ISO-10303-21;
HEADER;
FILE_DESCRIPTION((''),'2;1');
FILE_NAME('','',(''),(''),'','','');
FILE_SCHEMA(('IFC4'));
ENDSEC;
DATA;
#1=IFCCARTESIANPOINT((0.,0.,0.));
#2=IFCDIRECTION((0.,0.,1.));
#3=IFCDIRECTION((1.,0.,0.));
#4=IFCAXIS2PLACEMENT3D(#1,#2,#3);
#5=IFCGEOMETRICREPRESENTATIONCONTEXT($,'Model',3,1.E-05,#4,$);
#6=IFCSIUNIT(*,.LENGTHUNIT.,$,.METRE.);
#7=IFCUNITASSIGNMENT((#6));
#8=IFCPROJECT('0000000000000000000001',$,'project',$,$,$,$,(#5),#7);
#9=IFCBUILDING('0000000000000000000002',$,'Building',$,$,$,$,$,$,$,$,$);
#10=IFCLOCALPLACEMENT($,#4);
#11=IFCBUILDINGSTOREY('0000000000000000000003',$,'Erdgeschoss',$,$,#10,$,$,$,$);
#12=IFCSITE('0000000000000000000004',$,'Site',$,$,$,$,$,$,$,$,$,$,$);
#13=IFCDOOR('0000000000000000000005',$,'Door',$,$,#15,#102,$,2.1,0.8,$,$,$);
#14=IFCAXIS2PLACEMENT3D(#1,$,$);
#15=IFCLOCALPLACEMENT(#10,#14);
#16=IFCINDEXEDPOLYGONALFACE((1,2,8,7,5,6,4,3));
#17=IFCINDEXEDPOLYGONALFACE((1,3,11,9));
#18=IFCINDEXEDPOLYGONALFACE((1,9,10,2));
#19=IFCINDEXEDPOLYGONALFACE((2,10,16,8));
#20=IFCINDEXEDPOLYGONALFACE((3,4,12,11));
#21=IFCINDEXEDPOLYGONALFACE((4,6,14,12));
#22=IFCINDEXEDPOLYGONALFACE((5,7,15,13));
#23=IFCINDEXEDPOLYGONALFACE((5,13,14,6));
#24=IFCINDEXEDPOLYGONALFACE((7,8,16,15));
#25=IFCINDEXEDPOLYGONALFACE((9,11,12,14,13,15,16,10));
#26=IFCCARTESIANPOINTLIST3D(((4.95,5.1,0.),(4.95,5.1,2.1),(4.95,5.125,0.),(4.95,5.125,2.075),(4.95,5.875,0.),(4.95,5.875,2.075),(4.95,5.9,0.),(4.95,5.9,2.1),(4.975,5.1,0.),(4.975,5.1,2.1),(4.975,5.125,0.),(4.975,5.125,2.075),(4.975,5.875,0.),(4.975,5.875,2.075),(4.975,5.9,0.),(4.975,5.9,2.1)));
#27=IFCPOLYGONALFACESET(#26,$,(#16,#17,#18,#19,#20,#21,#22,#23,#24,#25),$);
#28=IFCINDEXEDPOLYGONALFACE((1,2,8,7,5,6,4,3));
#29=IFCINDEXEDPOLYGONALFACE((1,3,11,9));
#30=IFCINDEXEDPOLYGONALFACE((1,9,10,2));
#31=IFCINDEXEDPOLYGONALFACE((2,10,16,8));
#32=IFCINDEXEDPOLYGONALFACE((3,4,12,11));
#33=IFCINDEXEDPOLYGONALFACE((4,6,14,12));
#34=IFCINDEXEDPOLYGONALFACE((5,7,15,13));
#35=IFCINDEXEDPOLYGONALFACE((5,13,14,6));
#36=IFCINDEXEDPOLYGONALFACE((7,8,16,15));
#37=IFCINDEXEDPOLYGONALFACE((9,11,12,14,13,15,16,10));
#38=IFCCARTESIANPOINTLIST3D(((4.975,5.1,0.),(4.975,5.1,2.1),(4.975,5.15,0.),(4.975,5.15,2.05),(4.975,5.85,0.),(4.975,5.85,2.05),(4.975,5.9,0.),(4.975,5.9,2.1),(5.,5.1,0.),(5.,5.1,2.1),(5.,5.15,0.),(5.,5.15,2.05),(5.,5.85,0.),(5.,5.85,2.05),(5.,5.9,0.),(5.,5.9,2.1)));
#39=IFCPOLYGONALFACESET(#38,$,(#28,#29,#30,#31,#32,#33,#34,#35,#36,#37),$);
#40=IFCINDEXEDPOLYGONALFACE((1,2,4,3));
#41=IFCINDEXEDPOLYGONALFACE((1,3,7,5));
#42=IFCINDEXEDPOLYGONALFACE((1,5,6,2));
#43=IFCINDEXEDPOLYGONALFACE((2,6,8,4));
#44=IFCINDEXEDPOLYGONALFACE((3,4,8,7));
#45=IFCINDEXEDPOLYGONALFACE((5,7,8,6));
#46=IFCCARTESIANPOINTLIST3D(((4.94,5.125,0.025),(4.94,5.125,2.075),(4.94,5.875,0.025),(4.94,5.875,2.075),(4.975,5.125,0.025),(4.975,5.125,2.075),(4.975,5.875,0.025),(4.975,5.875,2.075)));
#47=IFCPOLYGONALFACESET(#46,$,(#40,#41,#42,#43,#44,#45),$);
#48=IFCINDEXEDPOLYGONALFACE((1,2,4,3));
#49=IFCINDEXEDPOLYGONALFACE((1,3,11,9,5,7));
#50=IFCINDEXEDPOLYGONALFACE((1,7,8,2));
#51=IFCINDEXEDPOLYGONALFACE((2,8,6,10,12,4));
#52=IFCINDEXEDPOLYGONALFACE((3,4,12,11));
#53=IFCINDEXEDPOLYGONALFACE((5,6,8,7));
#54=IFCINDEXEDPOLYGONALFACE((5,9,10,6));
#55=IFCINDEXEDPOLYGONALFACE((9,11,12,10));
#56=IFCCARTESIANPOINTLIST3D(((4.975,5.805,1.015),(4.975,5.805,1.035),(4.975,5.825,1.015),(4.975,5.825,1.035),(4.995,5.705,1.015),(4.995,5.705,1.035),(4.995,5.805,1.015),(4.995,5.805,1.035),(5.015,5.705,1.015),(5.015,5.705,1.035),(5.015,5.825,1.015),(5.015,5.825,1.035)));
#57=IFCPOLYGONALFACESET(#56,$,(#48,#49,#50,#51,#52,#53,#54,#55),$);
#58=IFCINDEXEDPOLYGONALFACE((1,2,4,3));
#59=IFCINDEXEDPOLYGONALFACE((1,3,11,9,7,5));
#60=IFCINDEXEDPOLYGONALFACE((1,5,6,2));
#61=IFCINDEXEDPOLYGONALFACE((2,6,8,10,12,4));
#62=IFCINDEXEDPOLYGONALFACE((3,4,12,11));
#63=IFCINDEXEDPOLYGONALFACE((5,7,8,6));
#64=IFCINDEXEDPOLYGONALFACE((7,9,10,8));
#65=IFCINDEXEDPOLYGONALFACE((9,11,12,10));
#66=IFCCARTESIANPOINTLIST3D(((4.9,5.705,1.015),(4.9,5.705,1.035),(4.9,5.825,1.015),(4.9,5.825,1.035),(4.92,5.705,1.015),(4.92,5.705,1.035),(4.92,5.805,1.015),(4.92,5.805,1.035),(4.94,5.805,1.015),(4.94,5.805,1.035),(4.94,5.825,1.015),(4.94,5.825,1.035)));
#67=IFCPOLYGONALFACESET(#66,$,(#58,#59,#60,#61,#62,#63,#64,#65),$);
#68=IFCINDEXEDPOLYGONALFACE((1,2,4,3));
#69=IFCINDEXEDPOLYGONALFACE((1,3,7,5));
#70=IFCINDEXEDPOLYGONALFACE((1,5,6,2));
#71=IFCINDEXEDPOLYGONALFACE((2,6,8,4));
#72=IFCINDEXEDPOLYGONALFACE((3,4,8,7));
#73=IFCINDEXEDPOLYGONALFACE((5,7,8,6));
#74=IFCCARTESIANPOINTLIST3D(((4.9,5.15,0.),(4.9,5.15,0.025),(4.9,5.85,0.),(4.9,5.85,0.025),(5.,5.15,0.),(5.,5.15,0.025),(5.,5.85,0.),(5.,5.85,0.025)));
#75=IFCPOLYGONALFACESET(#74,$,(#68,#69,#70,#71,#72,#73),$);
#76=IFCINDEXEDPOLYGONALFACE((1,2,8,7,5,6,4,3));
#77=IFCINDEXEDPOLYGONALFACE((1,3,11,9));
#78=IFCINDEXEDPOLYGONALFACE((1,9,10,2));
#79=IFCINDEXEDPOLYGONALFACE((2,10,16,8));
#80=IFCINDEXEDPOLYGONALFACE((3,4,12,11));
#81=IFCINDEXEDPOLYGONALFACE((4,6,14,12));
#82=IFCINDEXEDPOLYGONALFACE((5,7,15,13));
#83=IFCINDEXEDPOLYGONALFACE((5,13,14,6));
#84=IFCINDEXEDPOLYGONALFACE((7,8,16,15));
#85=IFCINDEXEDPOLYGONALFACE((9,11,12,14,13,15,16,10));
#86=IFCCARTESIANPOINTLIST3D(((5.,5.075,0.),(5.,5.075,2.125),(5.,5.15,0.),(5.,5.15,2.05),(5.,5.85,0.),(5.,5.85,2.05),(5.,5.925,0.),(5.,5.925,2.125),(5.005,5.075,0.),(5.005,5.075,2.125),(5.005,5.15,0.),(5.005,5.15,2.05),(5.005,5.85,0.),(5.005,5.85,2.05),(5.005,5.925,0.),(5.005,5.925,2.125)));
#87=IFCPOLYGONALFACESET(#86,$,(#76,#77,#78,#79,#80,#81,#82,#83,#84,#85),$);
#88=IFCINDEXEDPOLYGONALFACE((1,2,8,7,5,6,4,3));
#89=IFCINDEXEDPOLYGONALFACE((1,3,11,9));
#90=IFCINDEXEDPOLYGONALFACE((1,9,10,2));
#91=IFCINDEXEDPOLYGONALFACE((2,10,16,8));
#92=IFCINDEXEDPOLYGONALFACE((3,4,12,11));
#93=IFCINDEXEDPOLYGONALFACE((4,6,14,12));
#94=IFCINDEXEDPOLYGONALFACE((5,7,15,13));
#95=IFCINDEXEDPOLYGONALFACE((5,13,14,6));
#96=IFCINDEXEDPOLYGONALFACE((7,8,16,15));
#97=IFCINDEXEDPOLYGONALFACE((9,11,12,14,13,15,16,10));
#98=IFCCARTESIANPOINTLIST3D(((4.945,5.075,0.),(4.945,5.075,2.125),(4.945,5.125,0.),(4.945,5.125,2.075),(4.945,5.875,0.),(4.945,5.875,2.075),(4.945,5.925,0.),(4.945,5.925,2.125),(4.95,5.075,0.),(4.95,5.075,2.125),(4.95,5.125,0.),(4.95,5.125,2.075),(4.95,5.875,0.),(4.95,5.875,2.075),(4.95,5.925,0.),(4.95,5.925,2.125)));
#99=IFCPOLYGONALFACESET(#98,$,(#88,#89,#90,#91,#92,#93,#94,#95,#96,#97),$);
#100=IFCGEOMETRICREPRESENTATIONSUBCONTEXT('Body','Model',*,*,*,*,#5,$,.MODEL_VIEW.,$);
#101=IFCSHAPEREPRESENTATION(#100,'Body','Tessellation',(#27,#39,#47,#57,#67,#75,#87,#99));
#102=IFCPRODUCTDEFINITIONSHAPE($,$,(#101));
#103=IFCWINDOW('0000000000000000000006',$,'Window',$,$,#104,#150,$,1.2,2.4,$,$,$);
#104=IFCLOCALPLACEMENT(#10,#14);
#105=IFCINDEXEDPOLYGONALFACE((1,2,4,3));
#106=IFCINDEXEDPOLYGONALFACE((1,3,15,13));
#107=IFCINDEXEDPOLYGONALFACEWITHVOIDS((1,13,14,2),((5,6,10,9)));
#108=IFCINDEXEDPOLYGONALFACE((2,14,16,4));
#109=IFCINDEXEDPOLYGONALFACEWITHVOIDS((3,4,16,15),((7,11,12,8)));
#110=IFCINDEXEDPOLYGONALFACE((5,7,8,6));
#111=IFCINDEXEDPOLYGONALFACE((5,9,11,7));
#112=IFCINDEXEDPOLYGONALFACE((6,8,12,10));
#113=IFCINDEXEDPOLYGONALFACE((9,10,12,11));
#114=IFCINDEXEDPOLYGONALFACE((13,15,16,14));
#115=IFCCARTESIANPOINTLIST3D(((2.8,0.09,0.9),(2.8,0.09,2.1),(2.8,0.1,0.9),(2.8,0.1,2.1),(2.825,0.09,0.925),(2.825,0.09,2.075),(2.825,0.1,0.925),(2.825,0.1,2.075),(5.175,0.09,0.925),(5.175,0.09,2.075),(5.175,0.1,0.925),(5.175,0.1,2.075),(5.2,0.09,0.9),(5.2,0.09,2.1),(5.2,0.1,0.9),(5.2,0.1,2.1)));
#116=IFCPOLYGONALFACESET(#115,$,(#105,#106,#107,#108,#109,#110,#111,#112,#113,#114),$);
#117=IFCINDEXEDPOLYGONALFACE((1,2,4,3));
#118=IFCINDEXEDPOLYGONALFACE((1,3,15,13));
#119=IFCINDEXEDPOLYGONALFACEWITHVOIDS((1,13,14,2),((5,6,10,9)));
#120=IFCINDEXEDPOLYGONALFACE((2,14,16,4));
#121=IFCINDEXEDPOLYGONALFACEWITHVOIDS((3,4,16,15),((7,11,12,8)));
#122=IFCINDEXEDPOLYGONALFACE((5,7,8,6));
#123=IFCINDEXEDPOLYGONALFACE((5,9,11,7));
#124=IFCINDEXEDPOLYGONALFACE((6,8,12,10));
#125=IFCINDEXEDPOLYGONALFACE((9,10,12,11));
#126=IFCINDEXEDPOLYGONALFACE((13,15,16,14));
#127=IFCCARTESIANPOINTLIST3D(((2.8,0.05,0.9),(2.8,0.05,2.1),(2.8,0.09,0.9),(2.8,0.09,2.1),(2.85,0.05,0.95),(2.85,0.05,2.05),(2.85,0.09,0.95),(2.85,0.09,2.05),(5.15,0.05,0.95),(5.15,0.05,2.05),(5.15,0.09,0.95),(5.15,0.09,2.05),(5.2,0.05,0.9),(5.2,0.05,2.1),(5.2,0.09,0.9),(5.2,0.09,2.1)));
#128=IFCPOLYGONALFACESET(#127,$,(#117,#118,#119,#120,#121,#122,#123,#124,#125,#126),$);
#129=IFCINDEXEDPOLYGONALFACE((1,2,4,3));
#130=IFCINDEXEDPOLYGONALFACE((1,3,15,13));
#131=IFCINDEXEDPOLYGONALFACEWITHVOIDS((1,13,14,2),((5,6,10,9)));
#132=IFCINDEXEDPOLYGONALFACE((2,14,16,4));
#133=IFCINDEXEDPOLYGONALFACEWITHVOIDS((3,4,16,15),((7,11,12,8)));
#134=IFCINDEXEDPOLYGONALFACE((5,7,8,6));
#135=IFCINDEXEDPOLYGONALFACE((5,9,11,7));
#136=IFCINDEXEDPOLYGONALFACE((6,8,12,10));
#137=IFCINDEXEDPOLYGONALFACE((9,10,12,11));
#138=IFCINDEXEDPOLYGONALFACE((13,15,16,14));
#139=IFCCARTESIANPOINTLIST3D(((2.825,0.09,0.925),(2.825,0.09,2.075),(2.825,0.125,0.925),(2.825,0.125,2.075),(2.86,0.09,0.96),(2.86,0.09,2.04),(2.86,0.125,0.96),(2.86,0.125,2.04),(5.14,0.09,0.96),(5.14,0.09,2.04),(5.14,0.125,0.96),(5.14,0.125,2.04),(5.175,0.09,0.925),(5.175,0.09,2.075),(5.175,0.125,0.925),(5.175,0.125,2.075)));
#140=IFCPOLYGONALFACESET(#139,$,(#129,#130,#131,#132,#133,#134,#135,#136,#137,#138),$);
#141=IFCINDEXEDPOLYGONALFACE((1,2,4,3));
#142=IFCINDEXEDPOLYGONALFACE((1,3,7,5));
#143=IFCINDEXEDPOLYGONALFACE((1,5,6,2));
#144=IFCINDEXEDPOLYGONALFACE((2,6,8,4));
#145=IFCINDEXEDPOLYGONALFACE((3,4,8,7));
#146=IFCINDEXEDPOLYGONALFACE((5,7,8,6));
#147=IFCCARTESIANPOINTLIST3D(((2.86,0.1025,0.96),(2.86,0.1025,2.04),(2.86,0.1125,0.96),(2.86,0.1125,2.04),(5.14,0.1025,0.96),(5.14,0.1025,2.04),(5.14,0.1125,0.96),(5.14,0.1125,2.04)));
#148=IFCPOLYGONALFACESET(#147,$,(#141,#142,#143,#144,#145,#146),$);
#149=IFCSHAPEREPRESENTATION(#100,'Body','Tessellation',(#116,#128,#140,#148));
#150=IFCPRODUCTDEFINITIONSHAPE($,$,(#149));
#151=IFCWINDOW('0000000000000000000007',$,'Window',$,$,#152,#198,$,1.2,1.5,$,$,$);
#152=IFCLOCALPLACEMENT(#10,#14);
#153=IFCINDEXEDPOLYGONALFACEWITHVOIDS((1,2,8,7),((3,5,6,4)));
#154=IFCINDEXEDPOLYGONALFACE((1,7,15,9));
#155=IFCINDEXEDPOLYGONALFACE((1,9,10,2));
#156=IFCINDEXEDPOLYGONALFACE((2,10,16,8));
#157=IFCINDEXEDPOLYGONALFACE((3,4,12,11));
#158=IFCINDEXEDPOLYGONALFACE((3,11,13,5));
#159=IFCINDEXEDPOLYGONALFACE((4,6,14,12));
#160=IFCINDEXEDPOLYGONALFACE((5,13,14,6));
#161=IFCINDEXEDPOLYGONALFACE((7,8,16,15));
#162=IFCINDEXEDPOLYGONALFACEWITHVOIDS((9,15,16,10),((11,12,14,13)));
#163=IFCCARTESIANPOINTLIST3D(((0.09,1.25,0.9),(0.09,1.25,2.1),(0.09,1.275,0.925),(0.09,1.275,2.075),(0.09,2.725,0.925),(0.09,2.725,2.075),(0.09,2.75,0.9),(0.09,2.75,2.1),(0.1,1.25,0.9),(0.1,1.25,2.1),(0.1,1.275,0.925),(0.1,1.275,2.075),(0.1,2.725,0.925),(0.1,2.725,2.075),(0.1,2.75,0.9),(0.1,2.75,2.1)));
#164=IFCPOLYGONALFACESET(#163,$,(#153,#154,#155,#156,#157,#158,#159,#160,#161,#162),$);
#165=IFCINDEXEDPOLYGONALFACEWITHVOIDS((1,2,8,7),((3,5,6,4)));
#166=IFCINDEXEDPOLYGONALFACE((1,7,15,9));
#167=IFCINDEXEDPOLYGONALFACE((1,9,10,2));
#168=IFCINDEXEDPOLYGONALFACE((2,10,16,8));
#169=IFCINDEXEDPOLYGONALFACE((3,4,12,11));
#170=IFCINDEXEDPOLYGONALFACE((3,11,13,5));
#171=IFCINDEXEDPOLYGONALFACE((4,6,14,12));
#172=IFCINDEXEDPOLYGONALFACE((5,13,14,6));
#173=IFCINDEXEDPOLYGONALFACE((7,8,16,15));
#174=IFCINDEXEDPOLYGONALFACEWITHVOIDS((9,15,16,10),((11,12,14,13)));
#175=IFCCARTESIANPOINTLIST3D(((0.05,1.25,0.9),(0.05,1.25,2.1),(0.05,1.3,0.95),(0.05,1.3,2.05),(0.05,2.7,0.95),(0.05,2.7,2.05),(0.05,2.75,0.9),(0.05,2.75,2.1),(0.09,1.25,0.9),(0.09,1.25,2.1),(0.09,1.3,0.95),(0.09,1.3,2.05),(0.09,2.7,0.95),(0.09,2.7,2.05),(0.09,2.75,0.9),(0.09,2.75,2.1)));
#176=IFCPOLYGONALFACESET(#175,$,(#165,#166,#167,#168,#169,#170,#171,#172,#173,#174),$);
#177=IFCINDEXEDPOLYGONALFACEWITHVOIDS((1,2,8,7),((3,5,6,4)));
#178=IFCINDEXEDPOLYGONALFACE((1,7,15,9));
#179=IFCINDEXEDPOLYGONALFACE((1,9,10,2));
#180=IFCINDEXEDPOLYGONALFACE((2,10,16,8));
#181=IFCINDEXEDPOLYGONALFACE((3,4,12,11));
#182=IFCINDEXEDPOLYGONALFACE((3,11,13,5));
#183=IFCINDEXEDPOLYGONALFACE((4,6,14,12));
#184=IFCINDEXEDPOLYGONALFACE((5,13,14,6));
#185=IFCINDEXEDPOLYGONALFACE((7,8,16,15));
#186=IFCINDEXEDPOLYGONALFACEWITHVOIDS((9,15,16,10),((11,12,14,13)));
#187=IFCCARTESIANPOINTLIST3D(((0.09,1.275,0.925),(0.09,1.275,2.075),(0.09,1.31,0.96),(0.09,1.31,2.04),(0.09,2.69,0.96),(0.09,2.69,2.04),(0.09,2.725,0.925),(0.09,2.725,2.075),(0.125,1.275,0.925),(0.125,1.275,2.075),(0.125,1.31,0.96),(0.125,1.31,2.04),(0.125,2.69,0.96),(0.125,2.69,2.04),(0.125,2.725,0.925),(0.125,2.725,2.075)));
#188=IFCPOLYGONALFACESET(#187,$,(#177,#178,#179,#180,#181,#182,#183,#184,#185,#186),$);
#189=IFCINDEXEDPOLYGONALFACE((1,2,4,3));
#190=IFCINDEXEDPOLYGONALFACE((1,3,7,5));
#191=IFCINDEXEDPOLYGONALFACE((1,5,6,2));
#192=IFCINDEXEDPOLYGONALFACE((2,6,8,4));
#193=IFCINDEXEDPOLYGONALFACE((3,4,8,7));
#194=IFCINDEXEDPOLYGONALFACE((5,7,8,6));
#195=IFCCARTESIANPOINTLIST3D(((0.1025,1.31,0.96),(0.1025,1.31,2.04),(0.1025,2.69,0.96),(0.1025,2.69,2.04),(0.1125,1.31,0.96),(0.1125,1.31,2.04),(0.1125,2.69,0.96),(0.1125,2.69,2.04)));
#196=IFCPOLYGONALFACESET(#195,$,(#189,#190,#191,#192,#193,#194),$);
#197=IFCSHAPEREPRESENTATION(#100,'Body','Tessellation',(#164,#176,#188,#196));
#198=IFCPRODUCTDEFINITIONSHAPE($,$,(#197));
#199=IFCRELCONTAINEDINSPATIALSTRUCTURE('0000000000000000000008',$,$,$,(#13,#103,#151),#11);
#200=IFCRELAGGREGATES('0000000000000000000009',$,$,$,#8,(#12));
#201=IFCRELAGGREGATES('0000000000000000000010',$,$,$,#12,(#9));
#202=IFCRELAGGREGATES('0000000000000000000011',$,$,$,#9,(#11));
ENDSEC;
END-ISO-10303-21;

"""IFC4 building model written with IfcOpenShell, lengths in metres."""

from ifc_helpers import new_model, si_unit, frame, origin_with_axes, place, context, subcontext, project, spatial, line, indexed_curve, outline, extrude, element, save


model = new_model("IFC4")

# Units and contexts
model_context = context("Model", 3, precision=1e-05, world=origin_with_axes())
body_context = subcontext(model_context, "Body", "Model", "MODEL_VIEW")
ifc_project = project(units=[si_unit("LENGTHUNIT", "METRE")], contexts=[model_context])

# Site, building, storey
site = spatial("IfcSite", under=ifc_project, Name="Site")
building = spatial("IfcBuilding", under=site, Name="Building")
storey_placement = place(None, origin_with_axes())
storey = spatial("IfcBuildingStorey", under=building, at=storey_placement, Name="Erdgeschoss")

# Door
door_1_placement = place(storey_placement, frame((5.0, 5.1, 0.0), z_axis=(0.0, 0.0, 1.0), x_axis=(0.0, 1.0, 0.0)))
element("IfcDoor", 1, at=door_1_placement, inside=storey, Name="Door", OverallHeight=2.1, OverallWidth=0.8, context=body_context, shape_type="SweptSolid", body=[
    extrude(outline(indexed_curve([(0.0, 0.0), (0.0, 2.1), (0.8, 2.1), (0.8, 0.0), (0.775, 0.0), (0.775, 2.075), (0.025, 2.075), (0.025, 0.0)], segments=[line(1, 2, 3, 4, 5, 6, 7, 8, 1)])), frame((0.0, 0.025, 0.0), z_axis=(0.0, -1.0, 0.0), x_axis=(1.0, 0.0, 0.0)), (0.0, 0.0, -1.0), 0.025),
    extrude(outline(indexed_curve([(0.0, 0.0), (0.0, 2.1), (0.8, 2.1), (0.8, 0.0), (0.75, 0.0), (0.75, 2.05), (0.05, 2.05), (0.05, 0.0)], segments=[line(1, 2, 3, 4, 5, 6, 7, 8, 1)])), frame((0.0, 0.0, 0.0), z_axis=(0.0, -1.0, 0.0), x_axis=(1.0, 0.0, 0.0)), (0.0, 0.0, -1.0), 0.025),
    extrude(outline(indexed_curve([(0.0, 0.0), (0.75, 0.0), (0.75, 0.035), (0.0, 0.035)], segments=[line(1, 2, 3, 4, 1)])), frame((0.025, 0.025, 0.025), z_axis=(0.0, 0.0, 1.0), x_axis=(1.0, 0.0, 0.0)), (0.0, 0.0, 1.0), 2.05),
    extrude(outline(indexed_curve([(0.0, 0.0), (0.0, -0.04), (-0.12, -0.04), (-0.12, -0.02), (-0.02, -0.02), (-0.02, 0.0)], segments=[line(1, 2, 3, 4, 5, 6, 1)])), frame((0.725, 0.025, 1.015), z_axis=(0.0, 0.0, 1.0), x_axis=(1.0, 0.0, 0.0)), (0.0, 0.0, 1.0), 0.02),
    extrude(outline(indexed_curve([(0.0, 0.0), (0.0, 0.04), (-0.12, 0.04), (-0.12, 0.02), (-0.02, 0.02), (-0.02, 0.0)], segments=[line(1, 2, 3, 4, 5, 6, 1)])), frame((0.725, 0.06, 1.015), z_axis=(0.0, 0.0, 1.0), x_axis=(1.0, 0.0, 0.0)), (0.0, 0.0, 1.0), 0.02),
    extrude(outline(indexed_curve([(0.0, 0.0), (0.7, 0.0), (0.7, 0.1), (0.0, 0.1)], segments=[line(1, 2, 3, 4, 1)])), frame((0.05, 0.0, 0.0), z_axis=(0.0, 0.0, 1.0), x_axis=(1.0, 0.0, 0.0)), (0.0, 0.0, 1.0), 0.025),
    extrude(outline(indexed_curve([(0.0, 0.0), (0.0, 2.125), (0.85, 2.125), (0.85, 0.0), (0.775, 0.0), (0.775, 2.05), (0.075, 2.05), (0.075, 0.0)], segments=[line(1, 2, 3, 4, 5, 6, 7, 8, 1)])), frame((-0.025, -0.005, 0.0), z_axis=(0.0, -1.0, 0.0), x_axis=(1.0, 0.0, 0.0)), (0.0, 0.0, -1.0), 0.005),
    extrude(outline(indexed_curve([(0.0, 0.0), (0.0, 2.125), (0.85, 2.125), (0.85, 0.0), (0.8, 0.0), (0.8, 2.075), (0.05, 2.075), (0.05, 0.0)], segments=[line(1, 2, 3, 4, 5, 6, 7, 8, 1)])), frame((-0.025, 0.05, 0.0), z_axis=(0.0, -1.0, 0.0), x_axis=(1.0, 0.0, 0.0)), (0.0, 0.0, -1.0), 0.005),
])

# Windows
window_1_placement = place(storey_placement, frame((2.8, 0.0, 0.9), z_axis=(0.0, 0.0, 1.0), x_axis=(1.0, 0.0, 0.0)))
element("IfcWindow", 2, at=window_1_placement, inside=storey, Name="Window", OverallHeight=1.2, OverallWidth=2.4, context=body_context, shape_type="SweptSolid", body=[
    extrude(outline(indexed_curve([(0.0, 0.0), (2.4, 0.0), (2.4, 1.2), (0.0, 1.2)], segments=[line(1, 2, 3, 4, 1)]), holes=[indexed_curve([(0.025, 0.025), (2.375, 0.025), (2.375, 1.175), (0.025, 1.175)], segments=[line(1, 2, 3, 4, 1)])]), frame((0.0, 0.09, 0.0), z_axis=(0.0, -1.0, 0.0), x_axis=(1.0, 0.0, 0.0)), (0.0, 0.0, -1.0), 0.01),
    extrude(outline(indexed_curve([(0.0, 0.0), (2.4, 0.0), (2.4, 1.2), (0.0, 1.2)], segments=[line(1, 2, 3, 4, 1)]), holes=[indexed_curve([(0.05, 0.05), (2.35, 0.05), (2.35, 1.15), (0.05, 1.15)], segments=[line(1, 2, 3, 4, 1)])]), frame((0.0, 0.05, 0.0), z_axis=(0.0, -1.0, 0.0), x_axis=(1.0, 0.0, 0.0)), (0.0, 0.0, -1.0), 0.04),
    extrude(outline(indexed_curve([(0.0, 0.0), (2.35, 0.0), (2.35, 1.15), (0.0, 1.15)], segments=[line(1, 2, 3, 4, 1)]), holes=[indexed_curve([(0.035, 0.035), (2.315, 0.035), (2.315, 1.115), (0.035, 1.115)], segments=[line(1, 2, 3, 4, 1)])]), frame((0.025, 0.09, 0.025), z_axis=(0.0, -1.0, 0.0), x_axis=(1.0, 0.0, 0.0)), (0.0, 0.0, -1.0), 0.035),
    extrude(outline(indexed_curve([(0.035, 0.035), (2.315, 0.035), (2.315, 1.115), (0.035, 1.115)], segments=[line(1, 2, 3, 4, 1)])), frame((0.025, 0.1025, 0.025), z_axis=(0.0, -1.0, 0.0), x_axis=(1.0, 0.0, 0.0)), (0.0, 0.0, -1.0), 0.01),
])
for number, where, z_axis, x_axis, name in (
    (3, (0.0, 2.75, 0.9), (0.0, 0.0, 1.0), (0.0, -1.0, 0.0), "Window"),
):
    element("IfcWindow", number, at=place(storey_placement, frame(where, z_axis=z_axis, x_axis=x_axis)), inside=storey, Name=name, OverallHeight=1.2, OverallWidth=1.5, context=body_context, shape_type="SweptSolid", body=[
        extrude(outline(indexed_curve([(0.0, 0.0), (1.5, 0.0), (1.5, 1.2), (0.0, 1.2)], segments=[line(1, 2, 3, 4, 1)]), holes=[indexed_curve([(0.025, 0.025), (1.475, 0.025), (1.475, 1.175), (0.025, 1.175)], segments=[line(1, 2, 3, 4, 1)])]), frame((0.0, 0.09, 0.0), z_axis=(0.0, -1.0, 0.0), x_axis=(1.0, 0.0, 0.0)), (0.0, 0.0, -1.0), 0.01),
        extrude(outline(indexed_curve([(0.0, 0.0), (1.5, 0.0), (1.5, 1.2), (0.0, 1.2)], segments=[line(1, 2, 3, 4, 1)]), holes=[indexed_curve([(0.05, 0.05), (1.45, 0.05), (1.45, 1.15), (0.05, 1.15)], segments=[line(1, 2, 3, 4, 1)])]), frame((0.0, 0.05, 0.0), z_axis=(0.0, -1.0, 0.0), x_axis=(1.0, 0.0, 0.0)), (0.0, 0.0, -1.0), 0.04),
        extrude(outline(indexed_curve([(0.0, 0.0), (1.45, 0.0), (1.45, 1.15), (0.0, 1.15)], segments=[line(1, 2, 3, 4, 1)]), holes=[indexed_curve([(0.035, 0.035), (1.415, 0.035), (1.415, 1.115), (0.035, 1.115)], segments=[line(1, 2, 3, 4, 1)])]), frame((0.025, 0.09, 0.025), z_axis=(0.0, -1.0, 0.0), x_axis=(1.0, 0.0, 0.0)), (0.0, 0.0, -1.0), 0.035),
        extrude(outline(indexed_curve([(0.035, 0.035), (1.415, 0.035), (1.415, 1.115), (0.035, 1.115)], segments=[line(1, 2, 3, 4, 1)])), frame((0.025, 0.1025, 0.025), z_axis=(0.0, -1.0, 0.0), x_axis=(1.0, 0.0, 0.0)), (0.0, 0.0, -1.0), 0.01),
    ])

save(model, "model.ifc")
